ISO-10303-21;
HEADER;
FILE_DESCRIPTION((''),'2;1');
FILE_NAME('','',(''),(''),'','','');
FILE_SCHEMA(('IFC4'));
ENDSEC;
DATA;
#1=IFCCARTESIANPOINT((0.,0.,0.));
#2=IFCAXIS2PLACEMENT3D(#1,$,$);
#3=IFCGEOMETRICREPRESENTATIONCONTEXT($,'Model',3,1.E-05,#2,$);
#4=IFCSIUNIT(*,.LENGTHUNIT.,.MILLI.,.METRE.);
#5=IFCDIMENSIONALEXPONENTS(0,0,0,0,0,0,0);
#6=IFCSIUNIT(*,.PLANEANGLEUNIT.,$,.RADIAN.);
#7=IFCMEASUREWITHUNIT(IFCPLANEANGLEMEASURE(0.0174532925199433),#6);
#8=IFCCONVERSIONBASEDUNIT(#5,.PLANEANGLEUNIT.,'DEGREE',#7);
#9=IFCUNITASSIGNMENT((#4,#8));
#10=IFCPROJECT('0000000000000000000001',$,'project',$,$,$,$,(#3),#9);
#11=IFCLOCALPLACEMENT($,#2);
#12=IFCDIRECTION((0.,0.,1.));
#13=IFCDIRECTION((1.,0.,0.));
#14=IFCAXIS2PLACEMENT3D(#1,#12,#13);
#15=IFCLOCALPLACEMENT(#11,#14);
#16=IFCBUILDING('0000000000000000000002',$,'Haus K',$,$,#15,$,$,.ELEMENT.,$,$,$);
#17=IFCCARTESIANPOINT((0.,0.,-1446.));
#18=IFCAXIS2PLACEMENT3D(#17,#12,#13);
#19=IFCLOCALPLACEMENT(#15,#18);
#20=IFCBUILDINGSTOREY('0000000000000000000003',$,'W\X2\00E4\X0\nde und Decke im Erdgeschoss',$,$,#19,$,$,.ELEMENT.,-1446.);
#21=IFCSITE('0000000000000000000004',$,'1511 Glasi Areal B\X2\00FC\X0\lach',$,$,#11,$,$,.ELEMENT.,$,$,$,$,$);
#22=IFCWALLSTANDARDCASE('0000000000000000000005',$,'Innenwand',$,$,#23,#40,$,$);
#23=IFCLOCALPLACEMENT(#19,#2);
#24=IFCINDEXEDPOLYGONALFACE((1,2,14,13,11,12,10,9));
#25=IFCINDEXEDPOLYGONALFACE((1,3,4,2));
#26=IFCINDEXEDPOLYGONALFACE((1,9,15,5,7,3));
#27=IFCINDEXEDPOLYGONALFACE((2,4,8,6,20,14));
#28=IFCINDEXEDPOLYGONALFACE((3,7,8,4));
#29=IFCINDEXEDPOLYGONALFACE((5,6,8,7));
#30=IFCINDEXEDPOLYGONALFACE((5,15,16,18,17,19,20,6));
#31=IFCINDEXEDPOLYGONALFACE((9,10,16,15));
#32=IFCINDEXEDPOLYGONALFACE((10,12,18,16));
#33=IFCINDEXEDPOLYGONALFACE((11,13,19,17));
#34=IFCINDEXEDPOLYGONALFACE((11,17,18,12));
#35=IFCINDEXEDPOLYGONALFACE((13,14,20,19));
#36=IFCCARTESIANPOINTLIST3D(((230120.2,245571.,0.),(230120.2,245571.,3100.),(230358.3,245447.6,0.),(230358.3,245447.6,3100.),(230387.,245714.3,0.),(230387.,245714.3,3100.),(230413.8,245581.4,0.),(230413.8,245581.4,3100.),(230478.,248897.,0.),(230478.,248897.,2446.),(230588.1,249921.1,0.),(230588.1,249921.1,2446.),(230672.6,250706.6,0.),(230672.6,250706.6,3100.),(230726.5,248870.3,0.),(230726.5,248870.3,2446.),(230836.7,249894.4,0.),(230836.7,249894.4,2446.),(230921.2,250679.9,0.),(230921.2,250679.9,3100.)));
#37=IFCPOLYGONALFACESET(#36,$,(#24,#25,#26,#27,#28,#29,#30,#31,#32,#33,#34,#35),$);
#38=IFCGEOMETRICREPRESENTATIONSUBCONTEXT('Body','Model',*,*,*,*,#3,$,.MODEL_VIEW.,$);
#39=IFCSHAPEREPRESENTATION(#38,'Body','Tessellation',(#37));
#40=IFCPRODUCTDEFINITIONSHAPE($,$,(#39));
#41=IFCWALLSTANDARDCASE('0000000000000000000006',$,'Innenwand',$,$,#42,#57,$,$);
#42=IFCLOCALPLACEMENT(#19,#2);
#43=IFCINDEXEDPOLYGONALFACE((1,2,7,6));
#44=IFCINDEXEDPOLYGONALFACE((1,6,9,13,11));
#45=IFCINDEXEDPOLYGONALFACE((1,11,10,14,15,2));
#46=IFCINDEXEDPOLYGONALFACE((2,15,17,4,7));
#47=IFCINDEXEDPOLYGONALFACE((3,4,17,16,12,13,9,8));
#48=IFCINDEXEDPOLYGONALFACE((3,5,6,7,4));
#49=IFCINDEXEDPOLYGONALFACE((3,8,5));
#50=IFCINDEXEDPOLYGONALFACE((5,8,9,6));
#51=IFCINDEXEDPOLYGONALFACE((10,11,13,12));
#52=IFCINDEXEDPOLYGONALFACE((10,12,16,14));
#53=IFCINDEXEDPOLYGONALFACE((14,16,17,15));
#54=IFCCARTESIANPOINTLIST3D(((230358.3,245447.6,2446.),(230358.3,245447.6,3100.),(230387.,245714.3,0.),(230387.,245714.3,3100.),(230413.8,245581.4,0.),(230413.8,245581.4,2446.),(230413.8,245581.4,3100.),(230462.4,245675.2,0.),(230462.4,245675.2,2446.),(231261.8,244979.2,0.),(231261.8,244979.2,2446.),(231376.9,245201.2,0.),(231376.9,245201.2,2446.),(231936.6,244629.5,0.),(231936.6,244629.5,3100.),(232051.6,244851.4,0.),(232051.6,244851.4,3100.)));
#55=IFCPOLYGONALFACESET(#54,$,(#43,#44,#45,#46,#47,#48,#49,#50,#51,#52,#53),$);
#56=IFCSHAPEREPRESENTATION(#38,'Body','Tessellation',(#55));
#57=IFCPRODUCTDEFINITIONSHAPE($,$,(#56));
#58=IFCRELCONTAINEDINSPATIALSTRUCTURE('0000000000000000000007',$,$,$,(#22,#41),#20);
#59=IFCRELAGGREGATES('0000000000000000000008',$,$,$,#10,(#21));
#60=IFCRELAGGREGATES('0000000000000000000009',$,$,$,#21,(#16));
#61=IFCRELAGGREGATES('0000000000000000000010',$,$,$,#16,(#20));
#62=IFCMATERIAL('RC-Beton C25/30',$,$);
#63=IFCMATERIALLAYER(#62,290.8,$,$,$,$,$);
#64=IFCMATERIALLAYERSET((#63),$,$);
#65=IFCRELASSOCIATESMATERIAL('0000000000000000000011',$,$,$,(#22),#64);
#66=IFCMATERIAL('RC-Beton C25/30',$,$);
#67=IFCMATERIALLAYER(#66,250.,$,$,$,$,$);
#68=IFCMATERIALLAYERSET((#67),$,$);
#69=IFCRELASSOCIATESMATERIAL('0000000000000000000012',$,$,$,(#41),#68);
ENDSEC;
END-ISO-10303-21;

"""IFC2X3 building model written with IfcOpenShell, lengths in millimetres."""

from ifc_helpers import new_model, entity, si_unit, converted_unit, frame, frame_2d, origin, origin_with_axes, place, context, subcontext, project, spatial, polyline, rectangle, outline, extrude, material, layer, layer_set, layer_usage, element, save


model = new_model("IFC2X3")

# Units and contexts
model_context = context("Model", 3, precision=1e-05, world=origin())
body_context = subcontext(model_context, "Body", "Model", "MODEL_VIEW")
ifc_project = project(units=[si_unit("LENGTHUNIT", "METRE", prefix="MILLI"), converted_unit("PLANEANGLEUNIT", "DEGREE", entity("IfcPlaneAngleMeasure", 0.0174532925199433), si_unit("PLANEANGLEUNIT", "RADIAN"), dimensions=[0, 0, 0, 0, 0, 0, 0])], contexts=[model_context])

# Site, building, storey
site_placement = place(None, origin())
site = spatial("IfcSite", under=ifc_project, at=site_placement, Name="1511 Glasi Areal Bülach", CompositionType="ELEMENT")
building_placement = place(site_placement, origin_with_axes())
building = spatial("IfcBuilding", under=site, at=building_placement, Name="Haus K", CompositionType="ELEMENT")
storey_placement = place(building_placement, frame((0.0, 0.0, -1446.0), z_axis=(0.0, 0.0, 1.0), x_axis=(1.0, 0.0, 0.0)))
storey = spatial("IfcBuildingStorey", under=building, at=storey_placement, Name="Wände und Decke im Erdgeschoss", CompositionType="ELEMENT", Elevation=-1446.0)

# Walls, openings
ifc_material_1 = material(Name="RC-Beton C25/30")
ifc_layer_1 = layer(ifc_material_1, 290.8)
ifc_layer_set_1 = layer_set([ifc_layer_1])
ifc_layer_usage_1 = layer_usage(ifc_layer_set_1, "AXIS2", "POSITIVE", 0.0)
wall_1_placement = place(storey_placement, frame((230672.6, 250706.6, 0.0), z_axis=(0.0, 0.0, 1.0), x_axis=(-0.106958, -0.994264, 0.0)))
wall_1 = element("IfcWallStandardCase", 1, at=wall_1_placement, inside=storey, material=ifc_layer_usage_1, Name="Innenwand", context=body_context, shape_type="SweptSolid", body=[
    extrude(outline(polyline([(0.0, 0.0), (5165.2, 0.0), (5262.5, 250.0), (5123.5, 290.8), (4994.2, 250.0), (0.0, 250.0), (0.0, 0.0)])), origin_with_axes(), (0.0, 0.0, 1.0), 3100.0),
])
opening_1_placement = place(wall_1_placement, frame((790.0, 0.0, 0.0), z_axis=(0.0, 1.0, 0.0), x_axis=(0.0, 0.0, 1.0)))
element("IfcOpeningElement", 2, at=opening_1_placement, cuts=wall_1, ObjectType="Opening", context=body_context, shape_type="SweptSolid", body=[
    extrude(rectangle(XDim=2446.0, YDim=1030.0, at=frame_2d((1223.0, 515.0), x_axis=(1.0, 0.0))), origin_with_axes(), (0.0, 0.0, 1.0), 250.0),
])
ifc_material_2 = material(Name="RC-Beton C25/30")
ifc_layer_2 = layer(ifc_material_2, 250.0)
ifc_layer_set_2 = layer_set([ifc_layer_2])
ifc_layer_usage_2 = layer_usage(ifc_layer_set_2, "AXIS2", "POSITIVE", 0.0)
wall_2_placement = place(storey_placement, frame((232051.6, 244851.4, 0.0), z_axis=(0.0, 0.0, 1.0), x_axis=(-0.887815, 0.4602, 0.0)))
wall_2 = element("IfcWallStandardCase", 3, at=wall_2_placement, inside=storey, material=ifc_layer_usage_2, Name="Innenwand", context=body_context, shape_type="SweptSolid", body=[
    extrude(outline(polyline([(0.0, 0.0), (1874.9, 0.0), (1790.0, 105.7), (1777.7, 250.0), (0.0, 250.0), (0.0, 0.0)])), origin_with_axes(), (0.0, 0.0, 1.0), 3100.0),
])
opening_2_placement = place(wall_2_placement, frame((760.0, 0.0, 0.0), z_axis=(0.0, 1.0, 0.0), x_axis=(0.0, 0.0, 1.0)))
element("IfcOpeningElement", 4, at=opening_2_placement, cuts=wall_2, ObjectType="Opening", context=body_context, shape_type="SweptSolid", body=[
    extrude(rectangle(XDim=2446.0, YDim=1030.0, at=frame_2d((1223.0, 515.0), x_axis=(1.0, 0.0))), origin_with_axes(), (0.0, 0.0, 1.0), 250.0),
])

save(model, "model.ifc")
